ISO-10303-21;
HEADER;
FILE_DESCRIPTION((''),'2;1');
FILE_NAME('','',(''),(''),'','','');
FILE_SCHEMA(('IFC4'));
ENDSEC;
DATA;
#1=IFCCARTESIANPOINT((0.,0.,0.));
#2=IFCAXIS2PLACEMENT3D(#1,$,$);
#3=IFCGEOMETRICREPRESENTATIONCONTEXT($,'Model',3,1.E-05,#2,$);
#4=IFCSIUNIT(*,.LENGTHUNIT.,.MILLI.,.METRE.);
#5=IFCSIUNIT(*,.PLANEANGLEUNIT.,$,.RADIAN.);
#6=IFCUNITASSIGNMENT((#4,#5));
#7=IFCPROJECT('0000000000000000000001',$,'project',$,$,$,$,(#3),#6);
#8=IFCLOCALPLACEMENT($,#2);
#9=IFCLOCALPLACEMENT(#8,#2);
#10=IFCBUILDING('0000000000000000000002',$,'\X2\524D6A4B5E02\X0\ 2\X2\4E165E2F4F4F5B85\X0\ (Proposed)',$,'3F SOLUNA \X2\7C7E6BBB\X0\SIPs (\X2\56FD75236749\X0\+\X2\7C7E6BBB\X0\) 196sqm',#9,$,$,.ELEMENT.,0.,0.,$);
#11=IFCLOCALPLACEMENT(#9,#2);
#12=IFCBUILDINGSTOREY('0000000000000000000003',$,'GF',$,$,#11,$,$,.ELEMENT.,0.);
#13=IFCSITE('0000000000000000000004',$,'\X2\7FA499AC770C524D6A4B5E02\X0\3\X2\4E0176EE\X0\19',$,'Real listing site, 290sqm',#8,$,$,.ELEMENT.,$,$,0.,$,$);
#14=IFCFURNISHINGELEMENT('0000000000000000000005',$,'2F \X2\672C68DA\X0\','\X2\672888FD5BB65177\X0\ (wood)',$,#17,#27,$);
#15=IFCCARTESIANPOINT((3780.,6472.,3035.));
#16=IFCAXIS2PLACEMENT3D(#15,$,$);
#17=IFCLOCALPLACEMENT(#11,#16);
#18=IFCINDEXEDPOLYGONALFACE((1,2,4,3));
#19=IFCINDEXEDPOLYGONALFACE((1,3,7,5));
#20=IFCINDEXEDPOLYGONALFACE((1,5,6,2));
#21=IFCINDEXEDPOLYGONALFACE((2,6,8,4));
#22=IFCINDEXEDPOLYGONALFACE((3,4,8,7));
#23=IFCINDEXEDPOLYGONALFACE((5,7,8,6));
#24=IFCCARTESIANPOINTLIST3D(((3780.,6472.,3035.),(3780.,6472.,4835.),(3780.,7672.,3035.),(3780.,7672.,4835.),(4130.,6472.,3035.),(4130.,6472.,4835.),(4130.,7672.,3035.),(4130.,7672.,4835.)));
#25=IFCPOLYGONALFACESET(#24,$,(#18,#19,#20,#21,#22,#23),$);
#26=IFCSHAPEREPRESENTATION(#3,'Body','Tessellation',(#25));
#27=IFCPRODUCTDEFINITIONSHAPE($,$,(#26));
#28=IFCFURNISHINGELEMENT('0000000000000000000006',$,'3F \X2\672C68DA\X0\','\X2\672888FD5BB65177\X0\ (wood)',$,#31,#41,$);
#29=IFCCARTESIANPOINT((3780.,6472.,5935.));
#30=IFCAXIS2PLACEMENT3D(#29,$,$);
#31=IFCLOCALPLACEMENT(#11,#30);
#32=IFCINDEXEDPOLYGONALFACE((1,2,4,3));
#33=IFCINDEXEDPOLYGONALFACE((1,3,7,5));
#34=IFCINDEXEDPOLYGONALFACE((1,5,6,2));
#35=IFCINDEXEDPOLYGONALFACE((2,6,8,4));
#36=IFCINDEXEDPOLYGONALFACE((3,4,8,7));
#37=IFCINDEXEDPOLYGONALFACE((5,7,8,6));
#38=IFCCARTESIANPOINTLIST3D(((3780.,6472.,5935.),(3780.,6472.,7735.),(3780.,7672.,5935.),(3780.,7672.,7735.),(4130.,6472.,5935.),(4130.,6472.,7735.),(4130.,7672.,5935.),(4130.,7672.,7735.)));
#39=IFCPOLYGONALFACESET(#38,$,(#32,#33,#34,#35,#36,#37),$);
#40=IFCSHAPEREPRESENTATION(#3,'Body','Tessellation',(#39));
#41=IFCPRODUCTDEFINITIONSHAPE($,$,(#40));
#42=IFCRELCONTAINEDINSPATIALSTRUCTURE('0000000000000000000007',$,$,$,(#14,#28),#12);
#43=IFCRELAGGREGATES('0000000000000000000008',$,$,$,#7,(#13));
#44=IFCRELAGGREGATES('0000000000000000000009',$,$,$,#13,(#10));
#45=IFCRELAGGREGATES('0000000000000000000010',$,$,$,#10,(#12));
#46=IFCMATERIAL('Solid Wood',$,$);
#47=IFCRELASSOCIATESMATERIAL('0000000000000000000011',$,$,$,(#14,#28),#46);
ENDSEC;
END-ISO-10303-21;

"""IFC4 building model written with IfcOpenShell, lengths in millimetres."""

from ifc_helpers import new_model, si_unit, frame, frame_2d, origin, place, context, project, spatial, rectangle, extrude, material, element, save


model = new_model("IFC4")

# Units and contexts
model_context = context("Model", 3, precision=1e-05, world=origin())
ifc_project = project(units=[si_unit("LENGTHUNIT", "METRE", prefix="MILLI"), si_unit("PLANEANGLEUNIT", "RADIAN")], contexts=[model_context])

# Site, building, storey
site_placement = place(None, origin())
site = spatial("IfcSite", under=ifc_project, at=site_placement, Name="群馬県前橋市3丁目19", ObjectType="Real listing site, 290sqm", CompositionType="ELEMENT", RefElevation=0.0)
building_placement = place(site_placement, origin())
building = spatial("IfcBuilding", under=site, at=building_placement, Name="前橋市 2世帯住宅 (Proposed)", ObjectType="3F SOLUNA 籾殻SIPs (国産杉+籾殻) 196sqm", CompositionType="ELEMENT", ElevationOfRefHeight=0.0, ElevationOfTerrain=0.0)
storey_placement = place(building_placement, origin())
storey = spatial("IfcBuildingStorey", under=building, at=storey_placement, Name="GF", CompositionType="ELEMENT", Elevation=0.0)

# Shared definitions
ifc_material_1 = material(Name="Solid Wood")

# Furnishing elements
furnishing_1_placement = place(storey_placement, frame((3780.0, 6472.0, 3035.0)))
element("IfcFurnishingElement", 1, at=furnishing_1_placement, inside=storey, material=ifc_material_1, Name="2F 本棚", Description="木製家具 (wood)", context=model_context, shape_type="SweptSolid", body=[
    extrude(rectangle(XDim=350.0, YDim=1200.0, at=frame_2d((175.0, 600.0))), frame((3780.0, 6472.0, 3035.0)), (0.0, 0.0, 1.0), 1800.0),
])
furnishing_2_placement = place(storey_placement, frame((3780.0, 6472.0, 5935.0)))
element("IfcFurnishingElement", 2, at=furnishing_2_placement, inside=storey, material=ifc_material_1, Name="3F 本棚", Description="木製家具 (wood)", context=model_context, shape_type="SweptSolid", body=[
    extrude(rectangle(XDim=350.0, YDim=1200.0, at=frame_2d((175.0, 600.0))), frame((3780.0, 6472.0, 5935.0)), (0.0, 0.0, 1.0), 1800.0),
])

save(model, "model.ifc")
